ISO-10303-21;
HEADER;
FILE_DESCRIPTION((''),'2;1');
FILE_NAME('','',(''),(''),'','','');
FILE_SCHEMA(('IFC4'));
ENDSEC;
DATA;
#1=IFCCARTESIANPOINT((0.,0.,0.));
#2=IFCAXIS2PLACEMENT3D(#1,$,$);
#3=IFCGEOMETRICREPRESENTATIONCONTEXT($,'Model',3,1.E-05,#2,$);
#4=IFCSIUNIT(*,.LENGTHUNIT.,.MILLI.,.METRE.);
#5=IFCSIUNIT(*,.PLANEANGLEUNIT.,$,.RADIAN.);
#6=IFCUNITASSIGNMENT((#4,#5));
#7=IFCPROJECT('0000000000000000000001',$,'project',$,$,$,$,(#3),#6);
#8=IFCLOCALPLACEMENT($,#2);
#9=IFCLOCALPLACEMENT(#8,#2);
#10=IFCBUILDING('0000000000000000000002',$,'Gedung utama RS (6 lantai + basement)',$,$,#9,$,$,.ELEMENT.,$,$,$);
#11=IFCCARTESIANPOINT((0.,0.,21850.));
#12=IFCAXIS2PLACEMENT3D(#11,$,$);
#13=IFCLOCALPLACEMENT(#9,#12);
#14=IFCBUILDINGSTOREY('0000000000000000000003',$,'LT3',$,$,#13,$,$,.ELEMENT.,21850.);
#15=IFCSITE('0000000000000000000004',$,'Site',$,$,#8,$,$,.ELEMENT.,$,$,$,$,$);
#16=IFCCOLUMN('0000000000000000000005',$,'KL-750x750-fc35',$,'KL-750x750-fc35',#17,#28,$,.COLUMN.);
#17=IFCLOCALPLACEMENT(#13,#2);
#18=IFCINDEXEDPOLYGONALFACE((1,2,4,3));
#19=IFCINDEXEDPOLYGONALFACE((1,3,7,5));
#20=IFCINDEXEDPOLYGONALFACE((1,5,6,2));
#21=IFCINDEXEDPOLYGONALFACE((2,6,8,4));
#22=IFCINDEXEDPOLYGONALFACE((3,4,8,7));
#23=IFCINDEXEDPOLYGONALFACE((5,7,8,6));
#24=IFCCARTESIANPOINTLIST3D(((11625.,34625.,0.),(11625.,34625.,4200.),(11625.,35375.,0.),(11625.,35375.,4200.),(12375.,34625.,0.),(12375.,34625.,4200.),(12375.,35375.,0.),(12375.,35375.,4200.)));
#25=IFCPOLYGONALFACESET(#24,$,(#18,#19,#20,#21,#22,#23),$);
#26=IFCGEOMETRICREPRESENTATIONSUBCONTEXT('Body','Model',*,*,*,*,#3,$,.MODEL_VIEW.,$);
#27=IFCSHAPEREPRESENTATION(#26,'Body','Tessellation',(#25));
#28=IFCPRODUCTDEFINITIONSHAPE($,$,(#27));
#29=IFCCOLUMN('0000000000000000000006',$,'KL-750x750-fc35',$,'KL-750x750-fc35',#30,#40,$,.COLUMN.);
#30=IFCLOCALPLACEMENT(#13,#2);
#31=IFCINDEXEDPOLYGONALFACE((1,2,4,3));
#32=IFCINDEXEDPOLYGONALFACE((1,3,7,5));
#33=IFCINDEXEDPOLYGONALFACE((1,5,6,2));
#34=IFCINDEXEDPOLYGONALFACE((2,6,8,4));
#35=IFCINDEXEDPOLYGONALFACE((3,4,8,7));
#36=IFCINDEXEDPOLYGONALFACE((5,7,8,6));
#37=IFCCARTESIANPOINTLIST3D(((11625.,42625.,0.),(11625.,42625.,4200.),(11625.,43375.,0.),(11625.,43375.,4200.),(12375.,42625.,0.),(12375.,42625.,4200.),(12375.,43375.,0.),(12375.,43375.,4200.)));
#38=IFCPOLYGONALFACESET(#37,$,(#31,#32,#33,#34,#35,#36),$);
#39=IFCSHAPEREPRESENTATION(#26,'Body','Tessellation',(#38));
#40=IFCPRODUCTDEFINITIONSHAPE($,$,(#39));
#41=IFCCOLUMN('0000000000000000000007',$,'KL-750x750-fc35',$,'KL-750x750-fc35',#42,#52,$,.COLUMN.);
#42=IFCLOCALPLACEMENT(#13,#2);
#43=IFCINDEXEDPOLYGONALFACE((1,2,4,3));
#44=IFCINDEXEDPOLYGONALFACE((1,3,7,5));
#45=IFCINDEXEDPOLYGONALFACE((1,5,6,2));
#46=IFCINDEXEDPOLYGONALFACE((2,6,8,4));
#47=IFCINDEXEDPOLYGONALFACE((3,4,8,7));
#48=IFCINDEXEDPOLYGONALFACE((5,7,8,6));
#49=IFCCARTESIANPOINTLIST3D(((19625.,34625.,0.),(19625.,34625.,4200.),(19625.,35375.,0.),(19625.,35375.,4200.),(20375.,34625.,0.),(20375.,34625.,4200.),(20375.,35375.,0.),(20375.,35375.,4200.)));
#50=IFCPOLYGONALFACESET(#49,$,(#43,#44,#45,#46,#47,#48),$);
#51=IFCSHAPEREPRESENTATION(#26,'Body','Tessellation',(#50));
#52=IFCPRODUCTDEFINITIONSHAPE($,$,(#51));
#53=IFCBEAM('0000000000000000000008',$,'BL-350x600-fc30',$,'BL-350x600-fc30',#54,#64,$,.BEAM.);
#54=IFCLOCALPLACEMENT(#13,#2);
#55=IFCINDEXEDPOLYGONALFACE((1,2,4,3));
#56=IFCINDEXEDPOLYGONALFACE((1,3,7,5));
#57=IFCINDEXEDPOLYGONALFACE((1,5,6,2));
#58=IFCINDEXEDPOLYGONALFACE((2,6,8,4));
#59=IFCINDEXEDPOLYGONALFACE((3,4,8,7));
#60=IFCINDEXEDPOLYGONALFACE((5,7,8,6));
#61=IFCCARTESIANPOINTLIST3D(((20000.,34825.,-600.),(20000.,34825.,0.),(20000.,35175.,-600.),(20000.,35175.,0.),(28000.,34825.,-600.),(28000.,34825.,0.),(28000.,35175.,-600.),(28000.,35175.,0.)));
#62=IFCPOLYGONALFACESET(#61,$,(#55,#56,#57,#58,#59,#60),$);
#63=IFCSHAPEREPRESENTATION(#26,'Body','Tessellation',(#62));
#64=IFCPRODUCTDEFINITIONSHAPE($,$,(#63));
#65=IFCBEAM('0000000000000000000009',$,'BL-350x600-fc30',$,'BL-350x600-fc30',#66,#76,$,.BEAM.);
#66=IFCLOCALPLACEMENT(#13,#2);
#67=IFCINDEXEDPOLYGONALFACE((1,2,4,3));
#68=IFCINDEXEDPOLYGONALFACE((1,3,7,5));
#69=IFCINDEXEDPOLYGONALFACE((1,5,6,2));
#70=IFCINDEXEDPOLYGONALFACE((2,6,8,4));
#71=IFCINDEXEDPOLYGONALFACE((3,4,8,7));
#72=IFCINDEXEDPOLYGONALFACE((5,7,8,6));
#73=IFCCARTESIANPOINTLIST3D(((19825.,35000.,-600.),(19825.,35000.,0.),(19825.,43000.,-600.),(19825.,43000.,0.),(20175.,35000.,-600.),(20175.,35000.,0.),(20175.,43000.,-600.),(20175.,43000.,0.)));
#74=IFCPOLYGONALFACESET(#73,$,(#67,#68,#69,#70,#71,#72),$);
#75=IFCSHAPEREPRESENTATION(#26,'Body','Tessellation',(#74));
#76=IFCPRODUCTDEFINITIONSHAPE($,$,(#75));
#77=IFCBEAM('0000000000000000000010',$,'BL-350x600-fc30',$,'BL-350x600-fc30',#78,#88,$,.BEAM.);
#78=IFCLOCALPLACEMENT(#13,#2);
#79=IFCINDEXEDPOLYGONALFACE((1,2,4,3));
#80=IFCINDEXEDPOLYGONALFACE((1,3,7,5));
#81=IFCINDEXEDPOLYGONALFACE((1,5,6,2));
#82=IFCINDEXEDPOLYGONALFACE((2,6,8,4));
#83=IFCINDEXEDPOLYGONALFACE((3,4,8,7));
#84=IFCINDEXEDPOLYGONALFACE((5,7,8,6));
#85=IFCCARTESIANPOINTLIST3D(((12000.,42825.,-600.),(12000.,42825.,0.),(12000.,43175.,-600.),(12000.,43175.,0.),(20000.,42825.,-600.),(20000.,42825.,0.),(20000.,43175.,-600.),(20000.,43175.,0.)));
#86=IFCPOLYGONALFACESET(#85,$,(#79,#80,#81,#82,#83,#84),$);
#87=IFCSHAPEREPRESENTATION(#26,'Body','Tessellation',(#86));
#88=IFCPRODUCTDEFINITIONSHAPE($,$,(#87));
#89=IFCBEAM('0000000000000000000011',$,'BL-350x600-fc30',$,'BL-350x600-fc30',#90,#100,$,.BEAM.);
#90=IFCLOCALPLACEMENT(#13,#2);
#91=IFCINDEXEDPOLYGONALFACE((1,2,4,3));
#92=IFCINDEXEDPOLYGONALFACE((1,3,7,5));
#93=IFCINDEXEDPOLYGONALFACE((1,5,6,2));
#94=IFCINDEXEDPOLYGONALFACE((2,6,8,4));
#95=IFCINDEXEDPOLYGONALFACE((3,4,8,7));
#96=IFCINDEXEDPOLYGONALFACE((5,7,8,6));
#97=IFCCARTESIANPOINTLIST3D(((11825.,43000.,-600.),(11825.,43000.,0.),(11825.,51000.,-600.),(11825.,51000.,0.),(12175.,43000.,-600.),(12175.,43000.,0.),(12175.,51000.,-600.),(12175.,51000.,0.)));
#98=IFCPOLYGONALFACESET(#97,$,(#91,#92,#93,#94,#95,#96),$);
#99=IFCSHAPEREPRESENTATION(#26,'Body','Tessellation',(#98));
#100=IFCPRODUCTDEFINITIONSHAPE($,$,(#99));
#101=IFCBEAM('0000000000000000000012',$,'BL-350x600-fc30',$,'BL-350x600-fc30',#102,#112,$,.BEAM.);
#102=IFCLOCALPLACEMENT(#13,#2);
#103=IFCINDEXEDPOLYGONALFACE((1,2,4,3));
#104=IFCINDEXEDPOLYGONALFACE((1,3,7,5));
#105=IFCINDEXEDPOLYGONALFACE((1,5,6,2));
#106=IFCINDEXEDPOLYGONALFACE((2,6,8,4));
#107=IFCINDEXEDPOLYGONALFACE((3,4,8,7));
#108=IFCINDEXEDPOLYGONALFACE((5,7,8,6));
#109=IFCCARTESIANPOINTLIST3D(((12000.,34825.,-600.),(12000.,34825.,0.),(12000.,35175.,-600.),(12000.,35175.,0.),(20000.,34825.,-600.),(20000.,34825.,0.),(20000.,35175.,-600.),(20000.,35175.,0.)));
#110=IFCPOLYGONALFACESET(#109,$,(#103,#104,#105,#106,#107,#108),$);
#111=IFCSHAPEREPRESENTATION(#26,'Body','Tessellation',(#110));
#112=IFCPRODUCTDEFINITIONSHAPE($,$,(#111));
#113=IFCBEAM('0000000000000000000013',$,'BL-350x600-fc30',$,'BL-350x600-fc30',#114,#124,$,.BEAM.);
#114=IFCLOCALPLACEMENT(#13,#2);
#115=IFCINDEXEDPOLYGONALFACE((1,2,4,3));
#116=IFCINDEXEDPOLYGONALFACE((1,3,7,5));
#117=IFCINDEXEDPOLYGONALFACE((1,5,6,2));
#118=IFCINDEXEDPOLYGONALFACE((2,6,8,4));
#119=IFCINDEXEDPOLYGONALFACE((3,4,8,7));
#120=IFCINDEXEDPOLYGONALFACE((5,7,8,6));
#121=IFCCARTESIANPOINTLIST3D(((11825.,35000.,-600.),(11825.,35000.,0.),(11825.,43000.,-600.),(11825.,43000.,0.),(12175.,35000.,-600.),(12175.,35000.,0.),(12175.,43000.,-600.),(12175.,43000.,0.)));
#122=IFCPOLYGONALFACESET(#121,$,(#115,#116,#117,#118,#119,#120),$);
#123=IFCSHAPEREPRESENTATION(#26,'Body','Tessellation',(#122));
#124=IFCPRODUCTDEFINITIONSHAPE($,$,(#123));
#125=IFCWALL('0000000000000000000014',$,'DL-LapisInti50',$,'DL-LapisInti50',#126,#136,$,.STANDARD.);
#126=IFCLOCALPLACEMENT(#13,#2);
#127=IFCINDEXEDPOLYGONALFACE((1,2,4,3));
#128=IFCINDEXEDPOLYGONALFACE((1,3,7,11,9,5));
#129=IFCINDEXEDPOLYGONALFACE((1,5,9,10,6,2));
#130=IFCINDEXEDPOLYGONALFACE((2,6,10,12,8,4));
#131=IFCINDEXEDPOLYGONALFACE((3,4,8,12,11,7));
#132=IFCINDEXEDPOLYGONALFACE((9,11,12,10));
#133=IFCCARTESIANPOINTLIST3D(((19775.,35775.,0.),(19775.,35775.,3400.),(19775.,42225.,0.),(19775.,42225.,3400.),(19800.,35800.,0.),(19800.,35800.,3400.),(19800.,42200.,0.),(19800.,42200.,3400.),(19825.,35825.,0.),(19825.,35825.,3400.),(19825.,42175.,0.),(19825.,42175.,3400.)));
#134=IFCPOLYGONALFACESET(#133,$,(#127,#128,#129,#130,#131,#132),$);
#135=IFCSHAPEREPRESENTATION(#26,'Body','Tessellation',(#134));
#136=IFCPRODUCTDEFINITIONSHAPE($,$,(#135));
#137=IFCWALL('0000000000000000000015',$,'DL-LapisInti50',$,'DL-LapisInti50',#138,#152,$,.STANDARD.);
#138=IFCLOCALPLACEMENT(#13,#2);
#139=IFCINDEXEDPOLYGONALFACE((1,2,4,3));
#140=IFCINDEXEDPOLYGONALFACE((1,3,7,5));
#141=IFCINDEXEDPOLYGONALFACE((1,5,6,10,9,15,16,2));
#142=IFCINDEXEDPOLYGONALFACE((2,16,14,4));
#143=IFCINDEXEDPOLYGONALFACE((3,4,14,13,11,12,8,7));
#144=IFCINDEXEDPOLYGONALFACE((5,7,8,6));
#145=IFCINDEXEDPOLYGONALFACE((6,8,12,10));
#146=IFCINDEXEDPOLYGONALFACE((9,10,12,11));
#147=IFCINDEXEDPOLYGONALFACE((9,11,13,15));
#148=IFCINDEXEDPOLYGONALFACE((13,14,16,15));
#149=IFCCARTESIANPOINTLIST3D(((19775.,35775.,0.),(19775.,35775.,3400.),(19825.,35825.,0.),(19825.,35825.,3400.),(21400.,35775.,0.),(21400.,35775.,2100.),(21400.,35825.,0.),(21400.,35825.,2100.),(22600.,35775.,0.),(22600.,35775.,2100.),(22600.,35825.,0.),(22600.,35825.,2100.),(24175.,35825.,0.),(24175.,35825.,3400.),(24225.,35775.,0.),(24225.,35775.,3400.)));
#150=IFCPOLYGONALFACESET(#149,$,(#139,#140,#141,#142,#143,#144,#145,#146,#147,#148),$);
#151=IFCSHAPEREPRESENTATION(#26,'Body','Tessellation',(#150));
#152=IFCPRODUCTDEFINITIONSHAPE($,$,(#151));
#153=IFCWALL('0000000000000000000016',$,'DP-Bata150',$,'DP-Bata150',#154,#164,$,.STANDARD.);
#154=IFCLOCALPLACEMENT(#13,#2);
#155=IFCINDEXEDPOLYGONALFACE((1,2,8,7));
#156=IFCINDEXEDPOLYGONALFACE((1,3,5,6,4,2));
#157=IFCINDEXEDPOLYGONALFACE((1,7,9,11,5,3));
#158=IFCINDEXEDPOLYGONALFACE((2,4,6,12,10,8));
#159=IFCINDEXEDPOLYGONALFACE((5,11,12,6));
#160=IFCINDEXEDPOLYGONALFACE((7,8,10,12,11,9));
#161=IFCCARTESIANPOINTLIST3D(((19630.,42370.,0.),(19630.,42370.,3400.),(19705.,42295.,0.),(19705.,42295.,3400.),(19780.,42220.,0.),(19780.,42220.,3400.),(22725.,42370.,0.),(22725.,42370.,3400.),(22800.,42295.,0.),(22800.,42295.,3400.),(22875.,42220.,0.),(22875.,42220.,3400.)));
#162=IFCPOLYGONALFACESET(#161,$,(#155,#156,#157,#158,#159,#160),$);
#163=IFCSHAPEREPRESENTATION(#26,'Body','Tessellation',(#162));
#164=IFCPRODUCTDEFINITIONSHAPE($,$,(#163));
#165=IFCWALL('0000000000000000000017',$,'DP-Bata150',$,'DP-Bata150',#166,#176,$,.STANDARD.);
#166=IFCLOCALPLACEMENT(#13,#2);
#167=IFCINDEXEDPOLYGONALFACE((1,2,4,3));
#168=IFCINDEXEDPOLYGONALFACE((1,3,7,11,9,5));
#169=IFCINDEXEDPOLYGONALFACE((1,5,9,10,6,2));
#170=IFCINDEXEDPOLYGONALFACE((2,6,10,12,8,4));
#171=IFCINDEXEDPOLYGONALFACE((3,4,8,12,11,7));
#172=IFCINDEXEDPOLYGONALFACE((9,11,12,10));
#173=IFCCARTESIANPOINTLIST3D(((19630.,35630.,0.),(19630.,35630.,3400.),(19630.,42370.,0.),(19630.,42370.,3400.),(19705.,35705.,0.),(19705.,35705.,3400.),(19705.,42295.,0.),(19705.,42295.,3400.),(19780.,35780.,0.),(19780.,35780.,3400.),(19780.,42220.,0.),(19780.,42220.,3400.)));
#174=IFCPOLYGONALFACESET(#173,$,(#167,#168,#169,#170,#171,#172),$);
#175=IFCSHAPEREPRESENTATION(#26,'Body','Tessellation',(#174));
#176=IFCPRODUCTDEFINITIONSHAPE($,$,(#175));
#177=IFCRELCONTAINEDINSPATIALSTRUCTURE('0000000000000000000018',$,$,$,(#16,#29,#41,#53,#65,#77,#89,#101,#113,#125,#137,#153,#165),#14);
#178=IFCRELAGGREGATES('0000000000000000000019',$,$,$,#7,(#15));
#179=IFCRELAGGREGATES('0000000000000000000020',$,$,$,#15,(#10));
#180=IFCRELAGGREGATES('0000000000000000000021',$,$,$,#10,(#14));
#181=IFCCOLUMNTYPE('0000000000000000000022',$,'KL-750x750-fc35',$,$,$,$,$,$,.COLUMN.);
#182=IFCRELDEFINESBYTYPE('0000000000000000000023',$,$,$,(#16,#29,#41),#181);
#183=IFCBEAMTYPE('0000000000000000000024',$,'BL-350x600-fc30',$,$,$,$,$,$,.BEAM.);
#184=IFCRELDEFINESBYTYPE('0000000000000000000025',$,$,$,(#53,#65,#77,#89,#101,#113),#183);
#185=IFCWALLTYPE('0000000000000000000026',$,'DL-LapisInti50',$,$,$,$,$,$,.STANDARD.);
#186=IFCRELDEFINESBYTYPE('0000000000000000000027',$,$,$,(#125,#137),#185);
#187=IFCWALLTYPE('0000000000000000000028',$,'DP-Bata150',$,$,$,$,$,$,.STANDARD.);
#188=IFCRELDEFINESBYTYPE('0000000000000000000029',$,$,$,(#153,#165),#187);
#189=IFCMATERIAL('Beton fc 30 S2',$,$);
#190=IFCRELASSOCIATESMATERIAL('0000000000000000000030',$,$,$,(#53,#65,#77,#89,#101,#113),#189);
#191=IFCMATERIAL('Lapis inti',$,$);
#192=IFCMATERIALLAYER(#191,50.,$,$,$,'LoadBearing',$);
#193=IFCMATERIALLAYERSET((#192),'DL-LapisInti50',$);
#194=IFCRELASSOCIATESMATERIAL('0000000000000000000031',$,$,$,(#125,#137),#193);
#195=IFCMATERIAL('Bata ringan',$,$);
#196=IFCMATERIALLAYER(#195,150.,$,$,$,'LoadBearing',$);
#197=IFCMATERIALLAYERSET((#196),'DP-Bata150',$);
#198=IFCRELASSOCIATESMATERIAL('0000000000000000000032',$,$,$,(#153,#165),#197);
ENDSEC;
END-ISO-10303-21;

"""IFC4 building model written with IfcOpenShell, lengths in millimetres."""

from ifc_helpers import new_model, si_unit, frame, frame_2d, origin, origin_2d, place, context, subcontext, project, spatial, polyline, rectangle, outline, extrude, material, layer, layer_set, layer_usage, material_profile, profile_set, profile_usage, type_object, element, save


model = new_model("IFC4")

# Units and contexts
model_context = context("Model", 3, precision=1e-05, world=origin())
body_context = subcontext(model_context, "Body", "Model", "MODEL_VIEW")
ifc_project = project(units=[si_unit("LENGTHUNIT", "METRE", prefix="MILLI"), si_unit("PLANEANGLEUNIT", "RADIAN")], contexts=[model_context])

# Site, building, storey
site_placement = place(None, origin())
site = spatial("IfcSite", under=ifc_project, at=site_placement, Name="Site", CompositionType="ELEMENT")
building_placement = place(site_placement, origin())
building = spatial("IfcBuilding", under=site, at=building_placement, Name="Gedung utama RS (6 lantai + basement)", CompositionType="ELEMENT")
storey_placement = place(building_placement, frame((0.0, 0.0, 21850.0)))
storey = spatial("IfcBuildingStorey", under=building, at=storey_placement, Name="LT3", CompositionType="ELEMENT", Elevation=21850.0)

# Columns
ifc_material_profile_1 = material_profile(None, rectangle(XDim=750.0, YDim=750.0, at=origin_2d()), Name="KL-750x750-fc35")
ifc_profile_set_1 = profile_set([ifc_material_profile_1], Name="KL-750x750-fc35")
ifc_profile_usage_1 = profile_usage(ifc_profile_set_1, cardinal=5)
column_type = type_object("IfcColumnType", Name="KL-750x750-fc35", PredefinedType="COLUMN")
for number, where, z_axis, x_axis, name in (
    (1, (12000.0, 35000.0, 0.0), (0.0, 0.0, 1.0), (1.0, 0.0, 0.0), "KL-750x750-fc35"),
    (2, (12000.0, 43000.0, 0.0), (0.0, 0.0, 1.0), (1.0, 0.0, 0.0), "KL-750x750-fc35"),
    (3, (20000.0, 35000.0, 0.0), (0.0, 0.0, 1.0), (1.0, 0.0, 0.0), "KL-750x750-fc35"),
):
    element("IfcColumn", number, at=place(storey_placement, frame(where, z_axis=z_axis, x_axis=x_axis)), inside=storey, type_object=column_type, material=ifc_profile_usage_1, Name=name, ObjectType="KL-750x750-fc35", PredefinedType="COLUMN", context=body_context, shape_type="SweptSolid", body=[
        extrude(rectangle(XDim=750.0, YDim=750.0, at=origin_2d()), origin(), (0.0, 0.0, 1.0), 4200.0),
    ])

# Beams
ifc_material_1 = material(Name="Beton fc 30 S2")
ifc_material_profile_2 = material_profile(ifc_material_1, rectangle(XDim=350.0, YDim=600.0, at=origin_2d()), Name="BL-350x600-fc30")
ifc_profile_set_2 = profile_set([ifc_material_profile_2], Name="BL-350x600-fc30")
ifc_profile_usage_2 = profile_usage(ifc_profile_set_2, cardinal=8)
beam_type = type_object("IfcBeamType", Name="BL-350x600-fc30", PredefinedType="BEAM")
beam_1_placement = place(storey_placement, frame((20000.0, 35000.0, -300.0)))
element("IfcBeam", 4, at=beam_1_placement, inside=storey, type_object=beam_type, material=ifc_profile_usage_2, Name="BL-350x600-fc30", ObjectType="BL-350x600-fc30", PredefinedType="BEAM", context=body_context, shape_type="SweptSolid", body=[
    extrude(rectangle(XDim=350.0, YDim=600.0, at=origin_2d()), frame((0.0, 0.0, 0.0), z_axis=(1.0, 0.0, 0.0), x_axis=(0.0, 1.0, 0.0)), (0.0, 0.0, 1.0), 8000.0),
])
beam_2_placement = place(storey_placement, frame((20000.0, 35000.0, -300.0)))
element("IfcBeam", 5, at=beam_2_placement, inside=storey, type_object=beam_type, material=ifc_profile_usage_2, Name="BL-350x600-fc30", ObjectType="BL-350x600-fc30", PredefinedType="BEAM", context=body_context, shape_type="SweptSolid", body=[
    extrude(rectangle(XDim=350.0, YDim=600.0, at=origin_2d()), frame((0.0, 0.0, 0.0), z_axis=(0.0, 1.0, 0.0), x_axis=(-1.0, 0.0, 0.0)), (0.0, 0.0, 1.0), 8000.0),
])
beam_3_placement = place(storey_placement, frame((12000.0, 43000.0, -300.0)))
element("IfcBeam", 6, at=beam_3_placement, inside=storey, type_object=beam_type, material=ifc_profile_usage_2, Name="BL-350x600-fc30", ObjectType="BL-350x600-fc30", PredefinedType="BEAM", context=body_context, shape_type="SweptSolid", body=[
    extrude(rectangle(XDim=350.0, YDim=600.0, at=origin_2d()), frame((0.0, 0.0, 0.0), z_axis=(1.0, 0.0, 0.0), x_axis=(0.0, 1.0, 0.0)), (0.0, 0.0, 1.0), 8000.0),
])
beam_4_placement = place(storey_placement, frame((12000.0, 43000.0, -300.0)))
element("IfcBeam", 7, at=beam_4_placement, inside=storey, type_object=beam_type, material=ifc_profile_usage_2, Name="BL-350x600-fc30", ObjectType="BL-350x600-fc30", PredefinedType="BEAM", context=body_context, shape_type="SweptSolid", body=[
    extrude(rectangle(XDim=350.0, YDim=600.0, at=origin_2d()), frame((0.0, 0.0, 0.0), z_axis=(0.0, 1.0, 0.0), x_axis=(-1.0, 0.0, 0.0)), (0.0, 0.0, 1.0), 8000.0),
])
beam_5_placement = place(storey_placement, frame((12000.0, 35000.0, -300.0)))
element("IfcBeam", 8, at=beam_5_placement, inside=storey, type_object=beam_type, material=ifc_profile_usage_2, Name="BL-350x600-fc30", ObjectType="BL-350x600-fc30", PredefinedType="BEAM", context=body_context, shape_type="SweptSolid", body=[
    extrude(rectangle(XDim=350.0, YDim=600.0, at=origin_2d()), frame((0.0, 0.0, 0.0), z_axis=(1.0, 0.0, 0.0), x_axis=(0.0, 1.0, 0.0)), (0.0, 0.0, 1.0), 8000.0),
])
beam_6_placement = place(storey_placement, frame((12000.0, 35000.0, -300.0)))
element("IfcBeam", 9, at=beam_6_placement, inside=storey, type_object=beam_type, material=ifc_profile_usage_2, Name="BL-350x600-fc30", ObjectType="BL-350x600-fc30", PredefinedType="BEAM", context=body_context, shape_type="SweptSolid", body=[
    extrude(rectangle(XDim=350.0, YDim=600.0, at=origin_2d()), frame((0.0, 0.0, 0.0), z_axis=(0.0, 1.0, 0.0), x_axis=(-1.0, 0.0, 0.0)), (0.0, 0.0, 1.0), 8000.0),
])

# Wall
ifc_material_2 = material(Name="Lapis inti")
ifc_layer_1 = layer(ifc_material_2, 50.0, Category="LoadBearing")
ifc_layer_set_1 = layer_set([ifc_layer_1], Name="DL-LapisInti50")
ifc_layer_usage_1 = layer_usage(ifc_layer_set_1, "AXIS2", "NEGATIVE", 25.0)
wall_type_1 = type_object("IfcWallType", Name="DL-LapisInti50", PredefinedType="STANDARD")
wall_1_placement = place(storey_placement, frame((19800.0, 42200.0, 0.0), z_axis=(0.0, 0.0, 1.0), x_axis=(0.0, -1.0, 0.0)))
element("IfcWall", 10, at=wall_1_placement, inside=storey, type_object=wall_type_1, material=ifc_layer_usage_1, Name="DL-LapisInti50", ObjectType="DL-LapisInti50", PredefinedType="STANDARD", context=body_context, shape_type="SweptSolid", body=[
    extrude(outline(polyline([(-25.0, -25.0), (0.0, 0.0), (25.0, 25.0), (6375.0, 25.0), (6400.0, 0.0), (6425.0, -25.0), (-25.0, -25.0)])), origin(), (0.0, 0.0, 1.0), 3400.0),
])

# Wall, opening
wall_2_placement = place(storey_placement, frame((19800.0, 35800.0, 0.0), z_axis=(0.0, 0.0, 1.0), x_axis=(1.0, 0.0, 0.0)))
wall_2 = element("IfcWall", 11, at=wall_2_placement, inside=storey, type_object=wall_type_1, material=ifc_layer_usage_1, Name="DL-LapisInti50", ObjectType="DL-LapisInti50", PredefinedType="STANDARD", context=body_context, shape_type="SweptSolid", body=[
    extrude(outline(polyline([(-25.0, -25.0), (0.0, 0.0), (25.0, 25.0), (4375.0, 25.0), (4400.0, 0.0), (4425.0, -25.0), (-25.0, -25.0)])), origin(), (0.0, 0.0, 1.0), 3400.0),
])
opening_1_placement = place(wall_2_placement, frame((1600.0, 0.0, 0.0), z_axis=(0.0, 0.0, 1.0), x_axis=(1.0, 0.0, 0.0)))
element("IfcOpeningElement", 12, at=opening_1_placement, cuts=wall_2, PredefinedType="OPENING", context=body_context, shape_type="SweptSolid", body=[
    extrude(rectangle(XDim=1200.0, YDim=70.0, at=frame_2d((600.0, 0.0))), origin(), (0.0, 0.0, 1.0), 2100.0),
])

# Walls
ifc_material_3 = material(Name="Bata ringan")
ifc_layer_2 = layer(ifc_material_3, 150.0, Category="LoadBearing")
ifc_layer_set_2 = layer_set([ifc_layer_2], Name="DP-Bata150")
ifc_layer_usage_2 = layer_usage(ifc_layer_set_2, "AXIS2", "NEGATIVE", 75.0)
wall_type_2 = type_object("IfcWallType", Name="DP-Bata150", PredefinedType="STANDARD")
wall_3_placement = place(storey_placement, frame((22800.0, 42295.0, 0.0), z_axis=(0.0, 0.0, 1.0), x_axis=(-1.0, 0.0, 0.0)))
element("IfcWall", 13, at=wall_3_placement, inside=storey, type_object=wall_type_2, material=ifc_layer_usage_2, Name="DP-Bata150", ObjectType="DP-Bata150", PredefinedType="STANDARD", context=body_context, shape_type="SweptSolid", body=[
    extrude(outline(polyline([(75.0, -75.0), (0.0, 0.0), (-75.0, 75.0), (3020.0, 75.0), (3095.0, 0.0), (3170.0, -75.0), (75.0, -75.0)])), origin(), (0.0, 0.0, 1.0), 3400.0),
])
wall_4_placement = place(storey_placement, frame((19705.0, 42295.0, 0.0), z_axis=(0.0, 0.0, 1.0), x_axis=(0.0, -1.0, 0.0)))
element("IfcWall", 14, at=wall_4_placement, inside=storey, type_object=wall_type_2, material=ifc_layer_usage_2, Name="DP-Bata150", ObjectType="DP-Bata150", PredefinedType="STANDARD", context=body_context, shape_type="SweptSolid", body=[
    extrude(outline(polyline([(-75.0, -75.0), (0.0, 0.0), (75.0, 75.0), (6515.0, 75.0), (6590.0, 0.0), (6665.0, -75.0), (-75.0, -75.0)])), origin(), (0.0, 0.0, 1.0), 3400.0),
])

save(model, "model.ifc")
